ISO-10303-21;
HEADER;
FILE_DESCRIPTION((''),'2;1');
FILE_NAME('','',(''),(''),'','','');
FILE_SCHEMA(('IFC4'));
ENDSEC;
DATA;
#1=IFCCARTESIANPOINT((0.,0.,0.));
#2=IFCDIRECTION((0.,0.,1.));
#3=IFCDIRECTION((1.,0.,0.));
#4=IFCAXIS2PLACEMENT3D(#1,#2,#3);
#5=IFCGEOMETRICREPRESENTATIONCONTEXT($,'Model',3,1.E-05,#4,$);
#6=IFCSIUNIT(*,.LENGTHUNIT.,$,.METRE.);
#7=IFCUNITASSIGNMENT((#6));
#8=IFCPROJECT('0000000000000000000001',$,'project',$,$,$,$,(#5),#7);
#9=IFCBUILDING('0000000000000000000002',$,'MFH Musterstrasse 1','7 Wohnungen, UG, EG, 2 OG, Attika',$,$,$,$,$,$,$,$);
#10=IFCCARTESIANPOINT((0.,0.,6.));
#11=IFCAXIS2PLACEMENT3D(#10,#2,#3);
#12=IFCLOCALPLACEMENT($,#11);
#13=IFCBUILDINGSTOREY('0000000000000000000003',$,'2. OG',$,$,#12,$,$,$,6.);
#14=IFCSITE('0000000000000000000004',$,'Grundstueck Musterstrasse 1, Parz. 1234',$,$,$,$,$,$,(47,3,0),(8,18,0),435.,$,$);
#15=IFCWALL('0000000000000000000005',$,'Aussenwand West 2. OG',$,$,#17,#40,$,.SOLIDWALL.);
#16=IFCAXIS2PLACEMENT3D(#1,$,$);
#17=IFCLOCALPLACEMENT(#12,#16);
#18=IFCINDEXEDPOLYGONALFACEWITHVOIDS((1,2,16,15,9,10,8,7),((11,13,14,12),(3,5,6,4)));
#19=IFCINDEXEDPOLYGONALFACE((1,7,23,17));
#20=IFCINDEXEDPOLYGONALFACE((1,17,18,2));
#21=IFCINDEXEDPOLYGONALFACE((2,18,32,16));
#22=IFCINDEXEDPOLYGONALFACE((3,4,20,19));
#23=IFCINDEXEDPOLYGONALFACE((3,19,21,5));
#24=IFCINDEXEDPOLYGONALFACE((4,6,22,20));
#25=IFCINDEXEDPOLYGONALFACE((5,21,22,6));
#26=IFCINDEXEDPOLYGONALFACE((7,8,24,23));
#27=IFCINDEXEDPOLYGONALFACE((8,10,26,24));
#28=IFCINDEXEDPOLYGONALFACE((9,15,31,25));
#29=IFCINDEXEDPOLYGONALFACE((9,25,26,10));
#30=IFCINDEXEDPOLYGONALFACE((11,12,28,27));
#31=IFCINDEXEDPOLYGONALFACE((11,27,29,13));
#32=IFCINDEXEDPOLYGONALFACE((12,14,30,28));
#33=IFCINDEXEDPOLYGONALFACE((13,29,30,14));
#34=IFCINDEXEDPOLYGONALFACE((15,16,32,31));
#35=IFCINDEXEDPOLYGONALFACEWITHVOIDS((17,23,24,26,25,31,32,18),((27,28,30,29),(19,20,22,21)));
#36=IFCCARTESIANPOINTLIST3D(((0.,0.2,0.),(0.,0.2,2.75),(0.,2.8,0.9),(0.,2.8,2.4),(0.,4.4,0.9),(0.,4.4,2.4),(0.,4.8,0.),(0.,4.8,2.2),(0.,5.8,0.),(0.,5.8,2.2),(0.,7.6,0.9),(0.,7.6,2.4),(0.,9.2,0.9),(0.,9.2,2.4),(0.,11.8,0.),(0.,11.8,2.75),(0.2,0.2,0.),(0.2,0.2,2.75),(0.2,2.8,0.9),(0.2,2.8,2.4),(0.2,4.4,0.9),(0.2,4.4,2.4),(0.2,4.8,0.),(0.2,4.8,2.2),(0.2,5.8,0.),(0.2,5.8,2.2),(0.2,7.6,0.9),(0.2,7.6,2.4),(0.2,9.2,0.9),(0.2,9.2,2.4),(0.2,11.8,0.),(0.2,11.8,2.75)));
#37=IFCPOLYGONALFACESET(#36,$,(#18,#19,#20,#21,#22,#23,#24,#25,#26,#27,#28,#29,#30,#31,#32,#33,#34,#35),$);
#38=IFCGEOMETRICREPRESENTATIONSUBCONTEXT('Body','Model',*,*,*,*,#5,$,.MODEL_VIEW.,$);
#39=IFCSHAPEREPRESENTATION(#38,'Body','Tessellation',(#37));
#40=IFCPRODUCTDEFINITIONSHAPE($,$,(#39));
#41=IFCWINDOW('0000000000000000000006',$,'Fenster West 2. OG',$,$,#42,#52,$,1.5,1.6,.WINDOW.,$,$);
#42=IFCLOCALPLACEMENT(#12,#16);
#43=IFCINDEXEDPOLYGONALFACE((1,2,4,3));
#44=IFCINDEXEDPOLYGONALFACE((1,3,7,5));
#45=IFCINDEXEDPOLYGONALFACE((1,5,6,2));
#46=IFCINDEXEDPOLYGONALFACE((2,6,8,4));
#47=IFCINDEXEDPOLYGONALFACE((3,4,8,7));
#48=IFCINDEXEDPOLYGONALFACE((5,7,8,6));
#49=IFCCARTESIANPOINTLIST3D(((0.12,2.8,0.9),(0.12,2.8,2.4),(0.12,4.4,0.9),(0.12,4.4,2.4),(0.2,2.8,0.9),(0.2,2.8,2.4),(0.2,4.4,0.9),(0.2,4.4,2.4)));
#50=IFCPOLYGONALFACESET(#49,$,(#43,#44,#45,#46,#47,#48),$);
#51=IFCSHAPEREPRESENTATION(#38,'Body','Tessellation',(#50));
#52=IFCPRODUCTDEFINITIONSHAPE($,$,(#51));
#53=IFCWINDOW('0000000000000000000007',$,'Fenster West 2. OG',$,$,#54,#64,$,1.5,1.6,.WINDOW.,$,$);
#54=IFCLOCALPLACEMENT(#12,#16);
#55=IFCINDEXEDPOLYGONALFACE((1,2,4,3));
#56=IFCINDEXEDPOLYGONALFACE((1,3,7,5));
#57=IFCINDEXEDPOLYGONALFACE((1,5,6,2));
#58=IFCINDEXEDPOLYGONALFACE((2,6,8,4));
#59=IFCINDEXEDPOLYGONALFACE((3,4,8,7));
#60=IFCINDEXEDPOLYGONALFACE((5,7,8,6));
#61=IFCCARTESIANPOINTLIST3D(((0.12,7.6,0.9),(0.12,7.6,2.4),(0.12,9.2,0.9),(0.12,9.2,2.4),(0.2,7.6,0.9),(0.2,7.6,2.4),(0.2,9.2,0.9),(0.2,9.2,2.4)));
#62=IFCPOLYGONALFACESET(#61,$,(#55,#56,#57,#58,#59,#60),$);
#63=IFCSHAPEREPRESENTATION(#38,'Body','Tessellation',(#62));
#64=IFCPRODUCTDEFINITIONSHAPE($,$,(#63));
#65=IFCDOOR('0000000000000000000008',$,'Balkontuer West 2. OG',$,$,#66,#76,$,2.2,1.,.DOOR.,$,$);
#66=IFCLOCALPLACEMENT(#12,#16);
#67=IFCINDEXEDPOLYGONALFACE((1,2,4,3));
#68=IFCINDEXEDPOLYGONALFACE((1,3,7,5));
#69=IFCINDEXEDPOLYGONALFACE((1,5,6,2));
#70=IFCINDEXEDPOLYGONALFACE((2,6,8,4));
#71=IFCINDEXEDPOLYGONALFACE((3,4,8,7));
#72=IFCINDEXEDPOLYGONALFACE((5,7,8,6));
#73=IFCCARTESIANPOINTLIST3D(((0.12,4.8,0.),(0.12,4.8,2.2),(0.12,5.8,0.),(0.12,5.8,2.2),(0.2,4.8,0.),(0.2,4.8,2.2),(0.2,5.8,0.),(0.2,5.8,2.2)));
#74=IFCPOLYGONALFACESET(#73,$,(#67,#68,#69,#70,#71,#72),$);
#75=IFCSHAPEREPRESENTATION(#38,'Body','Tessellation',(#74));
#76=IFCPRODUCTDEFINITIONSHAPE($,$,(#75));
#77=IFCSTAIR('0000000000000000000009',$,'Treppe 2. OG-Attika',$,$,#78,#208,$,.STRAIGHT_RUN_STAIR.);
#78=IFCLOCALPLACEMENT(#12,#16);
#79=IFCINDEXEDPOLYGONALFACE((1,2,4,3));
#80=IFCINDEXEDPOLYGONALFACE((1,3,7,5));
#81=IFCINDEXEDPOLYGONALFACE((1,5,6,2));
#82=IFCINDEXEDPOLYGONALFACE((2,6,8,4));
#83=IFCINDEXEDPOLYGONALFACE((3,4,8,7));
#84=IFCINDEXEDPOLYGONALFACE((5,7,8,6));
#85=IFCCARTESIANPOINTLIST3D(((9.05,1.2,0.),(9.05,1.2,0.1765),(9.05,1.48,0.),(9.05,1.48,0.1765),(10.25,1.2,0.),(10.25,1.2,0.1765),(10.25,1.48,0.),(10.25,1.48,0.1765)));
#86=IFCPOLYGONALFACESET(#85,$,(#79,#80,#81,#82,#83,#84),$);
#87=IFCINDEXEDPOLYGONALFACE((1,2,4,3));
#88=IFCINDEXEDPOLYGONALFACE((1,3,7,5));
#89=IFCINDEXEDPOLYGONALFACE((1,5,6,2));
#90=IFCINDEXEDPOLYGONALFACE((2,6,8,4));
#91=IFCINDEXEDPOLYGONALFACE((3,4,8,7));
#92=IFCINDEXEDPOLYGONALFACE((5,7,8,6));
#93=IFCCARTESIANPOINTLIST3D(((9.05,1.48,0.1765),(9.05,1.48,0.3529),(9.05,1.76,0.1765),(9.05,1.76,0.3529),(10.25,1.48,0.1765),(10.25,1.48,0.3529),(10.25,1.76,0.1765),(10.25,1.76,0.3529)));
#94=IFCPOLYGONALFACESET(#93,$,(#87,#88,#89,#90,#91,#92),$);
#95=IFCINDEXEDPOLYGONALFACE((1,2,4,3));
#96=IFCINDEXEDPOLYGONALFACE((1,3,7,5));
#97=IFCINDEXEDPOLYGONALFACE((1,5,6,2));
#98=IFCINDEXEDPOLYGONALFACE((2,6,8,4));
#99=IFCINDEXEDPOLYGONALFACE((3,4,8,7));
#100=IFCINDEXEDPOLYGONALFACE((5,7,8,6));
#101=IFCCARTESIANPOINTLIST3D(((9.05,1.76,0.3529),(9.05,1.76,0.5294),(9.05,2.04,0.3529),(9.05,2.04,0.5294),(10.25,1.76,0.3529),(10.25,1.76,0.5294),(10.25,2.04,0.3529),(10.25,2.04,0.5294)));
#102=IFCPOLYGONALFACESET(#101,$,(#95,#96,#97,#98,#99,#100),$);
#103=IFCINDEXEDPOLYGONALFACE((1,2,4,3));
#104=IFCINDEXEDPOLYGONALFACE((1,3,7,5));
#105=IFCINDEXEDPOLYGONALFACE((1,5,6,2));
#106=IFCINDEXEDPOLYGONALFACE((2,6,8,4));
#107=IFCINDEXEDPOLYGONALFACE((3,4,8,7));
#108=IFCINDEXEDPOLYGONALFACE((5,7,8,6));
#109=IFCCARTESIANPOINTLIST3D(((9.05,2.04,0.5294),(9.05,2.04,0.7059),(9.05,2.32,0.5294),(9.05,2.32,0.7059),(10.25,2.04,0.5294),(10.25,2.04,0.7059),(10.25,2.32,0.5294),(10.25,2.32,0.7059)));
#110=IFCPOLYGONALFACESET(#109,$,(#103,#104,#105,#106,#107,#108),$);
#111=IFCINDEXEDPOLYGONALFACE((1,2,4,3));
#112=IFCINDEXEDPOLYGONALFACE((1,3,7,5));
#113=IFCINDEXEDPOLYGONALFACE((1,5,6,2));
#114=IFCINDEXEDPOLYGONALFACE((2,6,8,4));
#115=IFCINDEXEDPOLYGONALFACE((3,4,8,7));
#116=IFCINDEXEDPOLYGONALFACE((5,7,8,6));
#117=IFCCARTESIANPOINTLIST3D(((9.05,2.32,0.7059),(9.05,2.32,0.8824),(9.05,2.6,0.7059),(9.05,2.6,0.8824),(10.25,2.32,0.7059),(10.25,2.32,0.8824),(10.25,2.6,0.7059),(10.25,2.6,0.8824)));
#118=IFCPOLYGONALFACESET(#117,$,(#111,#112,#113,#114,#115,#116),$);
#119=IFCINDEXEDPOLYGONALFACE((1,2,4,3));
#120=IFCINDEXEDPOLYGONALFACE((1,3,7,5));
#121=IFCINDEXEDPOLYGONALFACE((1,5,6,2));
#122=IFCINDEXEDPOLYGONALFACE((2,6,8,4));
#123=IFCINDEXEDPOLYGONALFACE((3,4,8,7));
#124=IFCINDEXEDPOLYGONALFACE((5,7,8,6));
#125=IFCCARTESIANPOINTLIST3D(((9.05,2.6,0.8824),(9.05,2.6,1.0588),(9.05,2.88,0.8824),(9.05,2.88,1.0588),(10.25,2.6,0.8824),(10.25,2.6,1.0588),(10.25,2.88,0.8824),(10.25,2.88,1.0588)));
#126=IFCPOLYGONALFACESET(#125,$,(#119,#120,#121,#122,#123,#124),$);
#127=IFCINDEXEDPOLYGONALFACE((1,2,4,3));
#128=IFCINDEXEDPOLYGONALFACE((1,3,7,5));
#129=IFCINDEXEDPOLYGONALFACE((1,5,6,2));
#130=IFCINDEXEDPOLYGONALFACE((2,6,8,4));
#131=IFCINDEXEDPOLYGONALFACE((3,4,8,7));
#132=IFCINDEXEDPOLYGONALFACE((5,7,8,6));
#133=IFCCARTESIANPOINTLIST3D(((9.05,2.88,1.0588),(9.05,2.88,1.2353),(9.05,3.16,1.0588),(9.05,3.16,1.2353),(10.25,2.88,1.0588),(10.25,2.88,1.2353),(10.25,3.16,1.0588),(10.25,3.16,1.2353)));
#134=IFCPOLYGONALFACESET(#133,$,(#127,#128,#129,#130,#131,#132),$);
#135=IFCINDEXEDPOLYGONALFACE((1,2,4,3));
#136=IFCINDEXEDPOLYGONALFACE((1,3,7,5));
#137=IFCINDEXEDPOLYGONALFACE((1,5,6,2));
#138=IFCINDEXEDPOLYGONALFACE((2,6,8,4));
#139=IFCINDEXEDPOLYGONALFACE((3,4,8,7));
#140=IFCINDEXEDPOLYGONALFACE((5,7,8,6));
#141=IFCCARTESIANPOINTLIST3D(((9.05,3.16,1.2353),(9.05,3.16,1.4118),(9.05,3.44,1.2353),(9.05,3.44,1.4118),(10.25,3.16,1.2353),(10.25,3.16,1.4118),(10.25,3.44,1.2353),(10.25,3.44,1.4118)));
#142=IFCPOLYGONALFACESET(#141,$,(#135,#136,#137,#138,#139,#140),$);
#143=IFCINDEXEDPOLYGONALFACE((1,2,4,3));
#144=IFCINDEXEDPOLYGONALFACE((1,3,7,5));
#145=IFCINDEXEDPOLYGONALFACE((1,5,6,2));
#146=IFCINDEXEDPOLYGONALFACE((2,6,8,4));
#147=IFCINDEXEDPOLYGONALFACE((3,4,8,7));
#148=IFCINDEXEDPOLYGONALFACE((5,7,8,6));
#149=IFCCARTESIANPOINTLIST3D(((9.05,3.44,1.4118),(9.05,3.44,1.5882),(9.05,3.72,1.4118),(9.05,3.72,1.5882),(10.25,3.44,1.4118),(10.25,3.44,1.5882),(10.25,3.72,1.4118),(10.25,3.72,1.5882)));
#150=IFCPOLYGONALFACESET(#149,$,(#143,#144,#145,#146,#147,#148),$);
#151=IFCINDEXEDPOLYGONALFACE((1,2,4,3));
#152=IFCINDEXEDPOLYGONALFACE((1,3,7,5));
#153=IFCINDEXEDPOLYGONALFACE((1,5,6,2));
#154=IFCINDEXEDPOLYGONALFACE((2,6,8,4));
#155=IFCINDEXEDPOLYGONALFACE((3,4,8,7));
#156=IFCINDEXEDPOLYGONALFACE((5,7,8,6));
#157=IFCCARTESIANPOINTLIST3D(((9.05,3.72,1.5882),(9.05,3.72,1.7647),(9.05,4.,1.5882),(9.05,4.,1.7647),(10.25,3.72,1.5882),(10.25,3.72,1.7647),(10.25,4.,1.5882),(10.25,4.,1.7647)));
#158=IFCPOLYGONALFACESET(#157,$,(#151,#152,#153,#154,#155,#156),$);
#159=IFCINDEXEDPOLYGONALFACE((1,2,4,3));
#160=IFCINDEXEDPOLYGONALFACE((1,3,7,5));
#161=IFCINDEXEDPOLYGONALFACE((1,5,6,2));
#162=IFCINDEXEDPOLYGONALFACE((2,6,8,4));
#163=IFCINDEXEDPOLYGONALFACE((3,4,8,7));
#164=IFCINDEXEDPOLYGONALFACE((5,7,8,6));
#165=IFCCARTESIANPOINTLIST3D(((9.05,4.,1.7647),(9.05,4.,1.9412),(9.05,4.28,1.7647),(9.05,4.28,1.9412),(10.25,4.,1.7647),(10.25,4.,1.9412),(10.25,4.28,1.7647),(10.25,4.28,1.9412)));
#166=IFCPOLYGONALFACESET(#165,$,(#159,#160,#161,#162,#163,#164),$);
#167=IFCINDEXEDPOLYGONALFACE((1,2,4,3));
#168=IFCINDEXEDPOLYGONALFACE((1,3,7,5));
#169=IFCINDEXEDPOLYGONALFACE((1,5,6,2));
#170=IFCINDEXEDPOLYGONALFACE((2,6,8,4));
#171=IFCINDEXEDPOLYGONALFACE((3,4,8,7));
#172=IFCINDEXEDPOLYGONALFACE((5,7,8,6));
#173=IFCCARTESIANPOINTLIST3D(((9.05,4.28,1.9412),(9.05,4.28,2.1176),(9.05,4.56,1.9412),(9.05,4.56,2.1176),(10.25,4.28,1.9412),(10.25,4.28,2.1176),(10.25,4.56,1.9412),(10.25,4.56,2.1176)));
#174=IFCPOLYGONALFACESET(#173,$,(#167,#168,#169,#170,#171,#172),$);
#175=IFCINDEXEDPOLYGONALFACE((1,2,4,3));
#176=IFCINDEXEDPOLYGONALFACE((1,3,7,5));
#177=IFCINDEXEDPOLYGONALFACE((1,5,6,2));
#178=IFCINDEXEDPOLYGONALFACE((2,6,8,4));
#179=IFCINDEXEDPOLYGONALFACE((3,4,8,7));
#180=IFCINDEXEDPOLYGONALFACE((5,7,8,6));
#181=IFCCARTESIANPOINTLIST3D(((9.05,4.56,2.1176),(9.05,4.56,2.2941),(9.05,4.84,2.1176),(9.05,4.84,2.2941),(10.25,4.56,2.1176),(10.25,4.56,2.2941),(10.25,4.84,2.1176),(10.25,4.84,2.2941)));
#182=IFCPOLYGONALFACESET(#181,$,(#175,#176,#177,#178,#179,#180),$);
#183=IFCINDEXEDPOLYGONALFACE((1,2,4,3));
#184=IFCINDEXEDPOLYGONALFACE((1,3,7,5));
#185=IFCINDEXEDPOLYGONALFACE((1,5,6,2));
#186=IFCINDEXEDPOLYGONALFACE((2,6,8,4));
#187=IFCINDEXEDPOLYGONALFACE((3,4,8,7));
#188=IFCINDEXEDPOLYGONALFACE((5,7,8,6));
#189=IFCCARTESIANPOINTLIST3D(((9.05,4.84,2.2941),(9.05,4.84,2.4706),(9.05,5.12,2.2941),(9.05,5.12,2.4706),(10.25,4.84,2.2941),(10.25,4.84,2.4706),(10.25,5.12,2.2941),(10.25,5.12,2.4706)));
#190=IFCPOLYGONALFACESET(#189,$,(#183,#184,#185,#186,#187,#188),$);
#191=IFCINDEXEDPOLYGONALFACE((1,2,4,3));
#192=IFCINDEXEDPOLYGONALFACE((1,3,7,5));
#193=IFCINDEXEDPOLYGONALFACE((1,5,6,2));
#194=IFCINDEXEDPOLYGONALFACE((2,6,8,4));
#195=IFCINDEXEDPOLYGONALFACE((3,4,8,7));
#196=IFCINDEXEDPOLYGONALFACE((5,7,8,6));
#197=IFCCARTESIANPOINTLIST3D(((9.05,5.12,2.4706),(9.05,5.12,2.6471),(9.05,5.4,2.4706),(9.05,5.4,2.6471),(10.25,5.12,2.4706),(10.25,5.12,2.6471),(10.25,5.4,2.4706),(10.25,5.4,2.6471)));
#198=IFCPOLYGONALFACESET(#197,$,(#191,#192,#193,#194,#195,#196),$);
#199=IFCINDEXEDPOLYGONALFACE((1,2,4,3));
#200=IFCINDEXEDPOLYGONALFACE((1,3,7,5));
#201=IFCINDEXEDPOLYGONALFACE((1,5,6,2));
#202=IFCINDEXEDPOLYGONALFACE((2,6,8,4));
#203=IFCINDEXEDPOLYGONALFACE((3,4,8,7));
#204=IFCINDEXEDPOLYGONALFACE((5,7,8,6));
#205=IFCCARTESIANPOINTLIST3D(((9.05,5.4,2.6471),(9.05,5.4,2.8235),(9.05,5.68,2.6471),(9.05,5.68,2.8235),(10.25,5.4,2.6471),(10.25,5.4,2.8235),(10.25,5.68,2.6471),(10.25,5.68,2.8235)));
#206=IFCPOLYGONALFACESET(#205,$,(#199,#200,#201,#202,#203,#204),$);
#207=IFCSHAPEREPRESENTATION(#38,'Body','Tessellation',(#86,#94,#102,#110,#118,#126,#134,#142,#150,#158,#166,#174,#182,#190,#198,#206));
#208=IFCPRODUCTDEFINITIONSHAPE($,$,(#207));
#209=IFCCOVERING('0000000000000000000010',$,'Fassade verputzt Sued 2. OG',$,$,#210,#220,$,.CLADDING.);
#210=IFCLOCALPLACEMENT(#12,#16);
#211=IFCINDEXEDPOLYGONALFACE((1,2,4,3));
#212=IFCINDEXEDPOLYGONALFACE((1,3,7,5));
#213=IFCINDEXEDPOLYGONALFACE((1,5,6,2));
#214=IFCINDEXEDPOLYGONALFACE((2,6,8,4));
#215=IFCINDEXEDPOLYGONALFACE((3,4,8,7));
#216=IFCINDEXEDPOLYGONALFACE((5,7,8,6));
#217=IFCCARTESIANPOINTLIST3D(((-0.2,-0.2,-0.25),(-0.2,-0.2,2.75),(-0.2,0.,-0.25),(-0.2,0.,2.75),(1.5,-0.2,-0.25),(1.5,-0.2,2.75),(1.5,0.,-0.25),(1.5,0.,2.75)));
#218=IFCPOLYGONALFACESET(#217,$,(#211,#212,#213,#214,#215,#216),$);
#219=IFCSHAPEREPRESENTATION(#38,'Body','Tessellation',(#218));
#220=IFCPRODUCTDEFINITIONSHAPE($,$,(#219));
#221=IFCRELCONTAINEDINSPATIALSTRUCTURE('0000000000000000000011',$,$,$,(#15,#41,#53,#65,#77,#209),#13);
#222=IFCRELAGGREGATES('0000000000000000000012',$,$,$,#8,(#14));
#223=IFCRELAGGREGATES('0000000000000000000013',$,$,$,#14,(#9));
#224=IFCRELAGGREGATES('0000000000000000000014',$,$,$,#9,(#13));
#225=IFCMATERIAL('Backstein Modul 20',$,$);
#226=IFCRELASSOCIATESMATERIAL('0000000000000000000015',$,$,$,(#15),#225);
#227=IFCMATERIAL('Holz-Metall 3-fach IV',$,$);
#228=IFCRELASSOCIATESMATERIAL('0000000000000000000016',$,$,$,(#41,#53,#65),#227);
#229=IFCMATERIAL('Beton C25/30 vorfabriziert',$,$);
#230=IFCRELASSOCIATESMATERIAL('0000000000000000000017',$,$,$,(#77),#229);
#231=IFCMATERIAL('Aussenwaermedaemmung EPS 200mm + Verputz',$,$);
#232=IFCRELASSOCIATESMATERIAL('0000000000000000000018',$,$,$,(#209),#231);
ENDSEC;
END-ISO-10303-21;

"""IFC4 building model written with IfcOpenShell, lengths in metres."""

from ifc_helpers import new_model, si_unit, frame, frame_2d, origin_with_axes, place, context, subcontext, project, spatial, rectangle, extrude, material, element, fill, save


model = new_model("IFC4")

# Units and contexts
model_context = context("Model", 3, precision=1e-05, world=origin_with_axes())
body_context = subcontext(model_context, "Body", "Model", "MODEL_VIEW")
ifc_project = project(units=[si_unit("LENGTHUNIT", "METRE")], contexts=[model_context])

# Site, building, storey
site = spatial("IfcSite", under=ifc_project, Name="Grundstueck Musterstrasse 1, Parz. 1234", RefLatitude=(47, 3, 0), RefLongitude=(8, 18, 0), RefElevation=435.0)
building = spatial("IfcBuilding", under=site, Name="MFH Musterstrasse 1", Description="7 Wohnungen, UG, EG, 2 OG, Attika")
storey_placement = place(None, frame((0.0, 0.0, 6.0), z_axis=(0.0, 0.0, 1.0), x_axis=(1.0, 0.0, 0.0)))
storey = spatial("IfcBuildingStorey", under=building, at=storey_placement, Name="2. OG", Elevation=6.0)

# Shared definitions
ifc_material_1 = material(Name="Backstein Modul 20")

# Shared definitions
ifc_material_2 = material(Name="Holz-Metall 3-fach IV")

# Wall, openings, windows, door
wall_1_placement = place(storey_placement, frame((0.0, 0.2, 0.0), z_axis=(0.0, 0.0, 1.0), x_axis=(1.0, 0.0, 0.0)))
wall_1 = element("IfcWall", 1, at=wall_1_placement, inside=storey, material=ifc_material_1, Name="Aussenwand West 2. OG", PredefinedType="SOLIDWALL", context=body_context, shape_type="SweptSolid", body=[
    extrude(rectangle(XDim=0.2, YDim=11.6, at=frame_2d((0.1, 5.8))), origin_with_axes(), (0.0, 0.0, 1.0), 2.75),
])
opening_1_placement = place(wall_1_placement, frame((-0.21, 2.6, 0.9), z_axis=(0.0, 0.0, 1.0), x_axis=(1.0, 0.0, 0.0)))
opening_1 = element("IfcOpeningElement", 2, at=opening_1_placement, cuts=wall_1, context=body_context, shape_type="SweptSolid", body=[
    extrude(rectangle(XDim=0.42, YDim=1.6, at=frame_2d((0.21, 0.8))), origin_with_axes(), (0.0, 0.0, 1.0), 1.5),
])
opening_2_placement = place(wall_1_placement, frame((-0.21, 7.4, 0.9), z_axis=(0.0, 0.0, 1.0), x_axis=(1.0, 0.0, 0.0)))
opening_2 = element("IfcOpeningElement", 3, at=opening_2_placement, cuts=wall_1, context=body_context, shape_type="SweptSolid", body=[
    extrude(rectangle(XDim=0.42, YDim=1.6, at=frame_2d((0.21, 0.8))), origin_with_axes(), (0.0, 0.0, 1.0), 1.5),
])
opening_3_placement = place(wall_1_placement, frame((-0.21, 4.6, 0.0), z_axis=(0.0, 0.0, 1.0), x_axis=(1.0, 0.0, 0.0)))
opening_3 = element("IfcOpeningElement", 4, at=opening_3_placement, cuts=wall_1, context=body_context, shape_type="SweptSolid", body=[
    extrude(rectangle(XDim=0.42, YDim=1.0, at=frame_2d((0.21, 0.5))), origin_with_axes(), (0.0, 0.0, 1.0), 2.2),
])
window_1_placement = place(storey_placement, frame((0.12, 2.8, 0.9), z_axis=(0.0, 0.0, 1.0), x_axis=(1.0, 0.0, 0.0)))
window_1 = element("IfcWindow", 5, at=window_1_placement, inside=storey, material=ifc_material_2, Name="Fenster West 2. OG", OverallHeight=1.5, OverallWidth=1.6, PredefinedType="WINDOW", context=body_context, shape_type="SweptSolid", body=[
    extrude(rectangle(XDim=0.08, YDim=1.6, at=frame_2d((0.04, 0.8))), origin_with_axes(), (0.0, 0.0, 1.0), 1.5),
])
fill(opening_1, window_1)
window_2_placement = place(storey_placement, frame((0.12, 7.6, 0.9), z_axis=(0.0, 0.0, 1.0), x_axis=(1.0, 0.0, 0.0)))
window_2 = element("IfcWindow", 6, at=window_2_placement, inside=storey, material=ifc_material_2, Name="Fenster West 2. OG", OverallHeight=1.5, OverallWidth=1.6, PredefinedType="WINDOW", context=body_context, shape_type="SweptSolid", body=[
    extrude(rectangle(XDim=0.08, YDim=1.6, at=frame_2d((0.04, 0.8))), origin_with_axes(), (0.0, 0.0, 1.0), 1.5),
])
fill(opening_2, window_2)
door_1_placement = place(storey_placement, frame((0.12, 4.8, 0.0), z_axis=(0.0, 0.0, 1.0), x_axis=(1.0, 0.0, 0.0)))
door_1 = element("IfcDoor", 7, at=door_1_placement, inside=storey, material=ifc_material_2, Name="Balkontuer West 2. OG", OverallHeight=2.2, OverallWidth=1.0, PredefinedType="DOOR", context=body_context, shape_type="SweptSolid", body=[
    extrude(rectangle(XDim=0.08, YDim=1.0, at=frame_2d((0.04, 0.5))), origin_with_axes(), (0.0, 0.0, 1.0), 2.2),
])
fill(opening_3, door_1)

# Stair
ifc_material_3 = material(Name="Beton C25/30 vorfabriziert")
stair_placement = place(storey_placement, origin_with_axes())
element("IfcStair", 8, at=stair_placement, inside=storey, material=ifc_material_3, Name="Treppe 2. OG-Attika", PredefinedType="STRAIGHT_RUN_STAIR", context=body_context, shape_type="SweptSolid", body=[
    extrude(rectangle(XDim=1.2, YDim=0.28, at=frame_2d((0.6, 0.14))), frame((9.05, 1.2, 0.0)), (0.0, 0.0, 1.0), 0.1765),
    extrude(rectangle(XDim=1.2, YDim=0.28, at=frame_2d((0.6, 0.14))), frame((9.05, 1.48, 0.1765)), (0.0, 0.0, 1.0), 0.1765),
    extrude(rectangle(XDim=1.2, YDim=0.28, at=frame_2d((0.6, 0.14))), frame((9.05, 1.76, 0.3529)), (0.0, 0.0, 1.0), 0.1765),
    extrude(rectangle(XDim=1.2, YDim=0.28, at=frame_2d((0.6, 0.14))), frame((9.05, 2.04, 0.5294)), (0.0, 0.0, 1.0), 0.1765),
    extrude(rectangle(XDim=1.2, YDim=0.28, at=frame_2d((0.6, 0.14))), frame((9.05, 2.32, 0.7059)), (0.0, 0.0, 1.0), 0.1765),
    extrude(rectangle(XDim=1.2, YDim=0.28, at=frame_2d((0.6, 0.14))), frame((9.05, 2.6, 0.8824)), (0.0, 0.0, 1.0), 0.1765),
    extrude(rectangle(XDim=1.2, YDim=0.28, at=frame_2d((0.6, 0.14))), frame((9.05, 2.88, 1.0588)), (0.0, 0.0, 1.0), 0.1765),
    extrude(rectangle(XDim=1.2, YDim=0.28, at=frame_2d((0.6, 0.14))), frame((9.05, 3.16, 1.2353)), (0.0, 0.0, 1.0), 0.1765),
    extrude(rectangle(XDim=1.2, YDim=0.28, at=frame_2d((0.6, 0.14))), frame((9.05, 3.44, 1.4118)), (0.0, 0.0, 1.0), 0.1765),
    extrude(rectangle(XDim=1.2, YDim=0.28, at=frame_2d((0.6, 0.14))), frame((9.05, 3.72, 1.5882)), (0.0, 0.0, 1.0), 0.1765),
    extrude(rectangle(XDim=1.2, YDim=0.28, at=frame_2d((0.6, 0.14))), frame((9.05, 4.0, 1.7647)), (0.0, 0.0, 1.0), 0.1765),
    extrude(rectangle(XDim=1.2, YDim=0.28, at=frame_2d((0.6, 0.14))), frame((9.05, 4.28, 1.9412)), (0.0, 0.0, 1.0), 0.1765),
    extrude(rectangle(XDim=1.2, YDim=0.28, at=frame_2d((0.6, 0.14))), frame((9.05, 4.56, 2.1176)), (0.0, 0.0, 1.0), 0.1765),
    extrude(rectangle(XDim=1.2, YDim=0.28, at=frame_2d((0.6, 0.14))), frame((9.05, 4.84, 2.2941)), (0.0, 0.0, 1.0), 0.1765),
    extrude(rectangle(XDim=1.2, YDim=0.28, at=frame_2d((0.6, 0.14))), frame((9.05, 5.12, 2.4706)), (0.0, 0.0, 1.0), 0.1765),
    extrude(rectangle(XDim=1.2, YDim=0.28, at=frame_2d((0.6, 0.14))), frame((9.05, 5.4, 2.6471)), (0.0, 0.0, 1.0), 0.1765),
])

# Shared definitions
ifc_material_4 = material(Name="Aussenwaermedaemmung EPS 200mm + Verputz")

# Covering
covering_1_placement = place(storey_placement, frame((-0.2, -0.2, -0.25), z_axis=(0.0, 0.0, 1.0), x_axis=(1.0, 0.0, 0.0)))
element("IfcCovering", 9, at=covering_1_placement, inside=storey, material=ifc_material_4, Name="Fassade verputzt Sued 2. OG", PredefinedType="CLADDING", context=body_context, shape_type="SweptSolid", body=[
    extrude(rectangle(XDim=1.7, YDim=0.2, at=frame_2d((0.85, 0.1))), origin_with_axes(), (0.0, 0.0, 1.0), 3.0),
])

save(model, "model.ifc")
